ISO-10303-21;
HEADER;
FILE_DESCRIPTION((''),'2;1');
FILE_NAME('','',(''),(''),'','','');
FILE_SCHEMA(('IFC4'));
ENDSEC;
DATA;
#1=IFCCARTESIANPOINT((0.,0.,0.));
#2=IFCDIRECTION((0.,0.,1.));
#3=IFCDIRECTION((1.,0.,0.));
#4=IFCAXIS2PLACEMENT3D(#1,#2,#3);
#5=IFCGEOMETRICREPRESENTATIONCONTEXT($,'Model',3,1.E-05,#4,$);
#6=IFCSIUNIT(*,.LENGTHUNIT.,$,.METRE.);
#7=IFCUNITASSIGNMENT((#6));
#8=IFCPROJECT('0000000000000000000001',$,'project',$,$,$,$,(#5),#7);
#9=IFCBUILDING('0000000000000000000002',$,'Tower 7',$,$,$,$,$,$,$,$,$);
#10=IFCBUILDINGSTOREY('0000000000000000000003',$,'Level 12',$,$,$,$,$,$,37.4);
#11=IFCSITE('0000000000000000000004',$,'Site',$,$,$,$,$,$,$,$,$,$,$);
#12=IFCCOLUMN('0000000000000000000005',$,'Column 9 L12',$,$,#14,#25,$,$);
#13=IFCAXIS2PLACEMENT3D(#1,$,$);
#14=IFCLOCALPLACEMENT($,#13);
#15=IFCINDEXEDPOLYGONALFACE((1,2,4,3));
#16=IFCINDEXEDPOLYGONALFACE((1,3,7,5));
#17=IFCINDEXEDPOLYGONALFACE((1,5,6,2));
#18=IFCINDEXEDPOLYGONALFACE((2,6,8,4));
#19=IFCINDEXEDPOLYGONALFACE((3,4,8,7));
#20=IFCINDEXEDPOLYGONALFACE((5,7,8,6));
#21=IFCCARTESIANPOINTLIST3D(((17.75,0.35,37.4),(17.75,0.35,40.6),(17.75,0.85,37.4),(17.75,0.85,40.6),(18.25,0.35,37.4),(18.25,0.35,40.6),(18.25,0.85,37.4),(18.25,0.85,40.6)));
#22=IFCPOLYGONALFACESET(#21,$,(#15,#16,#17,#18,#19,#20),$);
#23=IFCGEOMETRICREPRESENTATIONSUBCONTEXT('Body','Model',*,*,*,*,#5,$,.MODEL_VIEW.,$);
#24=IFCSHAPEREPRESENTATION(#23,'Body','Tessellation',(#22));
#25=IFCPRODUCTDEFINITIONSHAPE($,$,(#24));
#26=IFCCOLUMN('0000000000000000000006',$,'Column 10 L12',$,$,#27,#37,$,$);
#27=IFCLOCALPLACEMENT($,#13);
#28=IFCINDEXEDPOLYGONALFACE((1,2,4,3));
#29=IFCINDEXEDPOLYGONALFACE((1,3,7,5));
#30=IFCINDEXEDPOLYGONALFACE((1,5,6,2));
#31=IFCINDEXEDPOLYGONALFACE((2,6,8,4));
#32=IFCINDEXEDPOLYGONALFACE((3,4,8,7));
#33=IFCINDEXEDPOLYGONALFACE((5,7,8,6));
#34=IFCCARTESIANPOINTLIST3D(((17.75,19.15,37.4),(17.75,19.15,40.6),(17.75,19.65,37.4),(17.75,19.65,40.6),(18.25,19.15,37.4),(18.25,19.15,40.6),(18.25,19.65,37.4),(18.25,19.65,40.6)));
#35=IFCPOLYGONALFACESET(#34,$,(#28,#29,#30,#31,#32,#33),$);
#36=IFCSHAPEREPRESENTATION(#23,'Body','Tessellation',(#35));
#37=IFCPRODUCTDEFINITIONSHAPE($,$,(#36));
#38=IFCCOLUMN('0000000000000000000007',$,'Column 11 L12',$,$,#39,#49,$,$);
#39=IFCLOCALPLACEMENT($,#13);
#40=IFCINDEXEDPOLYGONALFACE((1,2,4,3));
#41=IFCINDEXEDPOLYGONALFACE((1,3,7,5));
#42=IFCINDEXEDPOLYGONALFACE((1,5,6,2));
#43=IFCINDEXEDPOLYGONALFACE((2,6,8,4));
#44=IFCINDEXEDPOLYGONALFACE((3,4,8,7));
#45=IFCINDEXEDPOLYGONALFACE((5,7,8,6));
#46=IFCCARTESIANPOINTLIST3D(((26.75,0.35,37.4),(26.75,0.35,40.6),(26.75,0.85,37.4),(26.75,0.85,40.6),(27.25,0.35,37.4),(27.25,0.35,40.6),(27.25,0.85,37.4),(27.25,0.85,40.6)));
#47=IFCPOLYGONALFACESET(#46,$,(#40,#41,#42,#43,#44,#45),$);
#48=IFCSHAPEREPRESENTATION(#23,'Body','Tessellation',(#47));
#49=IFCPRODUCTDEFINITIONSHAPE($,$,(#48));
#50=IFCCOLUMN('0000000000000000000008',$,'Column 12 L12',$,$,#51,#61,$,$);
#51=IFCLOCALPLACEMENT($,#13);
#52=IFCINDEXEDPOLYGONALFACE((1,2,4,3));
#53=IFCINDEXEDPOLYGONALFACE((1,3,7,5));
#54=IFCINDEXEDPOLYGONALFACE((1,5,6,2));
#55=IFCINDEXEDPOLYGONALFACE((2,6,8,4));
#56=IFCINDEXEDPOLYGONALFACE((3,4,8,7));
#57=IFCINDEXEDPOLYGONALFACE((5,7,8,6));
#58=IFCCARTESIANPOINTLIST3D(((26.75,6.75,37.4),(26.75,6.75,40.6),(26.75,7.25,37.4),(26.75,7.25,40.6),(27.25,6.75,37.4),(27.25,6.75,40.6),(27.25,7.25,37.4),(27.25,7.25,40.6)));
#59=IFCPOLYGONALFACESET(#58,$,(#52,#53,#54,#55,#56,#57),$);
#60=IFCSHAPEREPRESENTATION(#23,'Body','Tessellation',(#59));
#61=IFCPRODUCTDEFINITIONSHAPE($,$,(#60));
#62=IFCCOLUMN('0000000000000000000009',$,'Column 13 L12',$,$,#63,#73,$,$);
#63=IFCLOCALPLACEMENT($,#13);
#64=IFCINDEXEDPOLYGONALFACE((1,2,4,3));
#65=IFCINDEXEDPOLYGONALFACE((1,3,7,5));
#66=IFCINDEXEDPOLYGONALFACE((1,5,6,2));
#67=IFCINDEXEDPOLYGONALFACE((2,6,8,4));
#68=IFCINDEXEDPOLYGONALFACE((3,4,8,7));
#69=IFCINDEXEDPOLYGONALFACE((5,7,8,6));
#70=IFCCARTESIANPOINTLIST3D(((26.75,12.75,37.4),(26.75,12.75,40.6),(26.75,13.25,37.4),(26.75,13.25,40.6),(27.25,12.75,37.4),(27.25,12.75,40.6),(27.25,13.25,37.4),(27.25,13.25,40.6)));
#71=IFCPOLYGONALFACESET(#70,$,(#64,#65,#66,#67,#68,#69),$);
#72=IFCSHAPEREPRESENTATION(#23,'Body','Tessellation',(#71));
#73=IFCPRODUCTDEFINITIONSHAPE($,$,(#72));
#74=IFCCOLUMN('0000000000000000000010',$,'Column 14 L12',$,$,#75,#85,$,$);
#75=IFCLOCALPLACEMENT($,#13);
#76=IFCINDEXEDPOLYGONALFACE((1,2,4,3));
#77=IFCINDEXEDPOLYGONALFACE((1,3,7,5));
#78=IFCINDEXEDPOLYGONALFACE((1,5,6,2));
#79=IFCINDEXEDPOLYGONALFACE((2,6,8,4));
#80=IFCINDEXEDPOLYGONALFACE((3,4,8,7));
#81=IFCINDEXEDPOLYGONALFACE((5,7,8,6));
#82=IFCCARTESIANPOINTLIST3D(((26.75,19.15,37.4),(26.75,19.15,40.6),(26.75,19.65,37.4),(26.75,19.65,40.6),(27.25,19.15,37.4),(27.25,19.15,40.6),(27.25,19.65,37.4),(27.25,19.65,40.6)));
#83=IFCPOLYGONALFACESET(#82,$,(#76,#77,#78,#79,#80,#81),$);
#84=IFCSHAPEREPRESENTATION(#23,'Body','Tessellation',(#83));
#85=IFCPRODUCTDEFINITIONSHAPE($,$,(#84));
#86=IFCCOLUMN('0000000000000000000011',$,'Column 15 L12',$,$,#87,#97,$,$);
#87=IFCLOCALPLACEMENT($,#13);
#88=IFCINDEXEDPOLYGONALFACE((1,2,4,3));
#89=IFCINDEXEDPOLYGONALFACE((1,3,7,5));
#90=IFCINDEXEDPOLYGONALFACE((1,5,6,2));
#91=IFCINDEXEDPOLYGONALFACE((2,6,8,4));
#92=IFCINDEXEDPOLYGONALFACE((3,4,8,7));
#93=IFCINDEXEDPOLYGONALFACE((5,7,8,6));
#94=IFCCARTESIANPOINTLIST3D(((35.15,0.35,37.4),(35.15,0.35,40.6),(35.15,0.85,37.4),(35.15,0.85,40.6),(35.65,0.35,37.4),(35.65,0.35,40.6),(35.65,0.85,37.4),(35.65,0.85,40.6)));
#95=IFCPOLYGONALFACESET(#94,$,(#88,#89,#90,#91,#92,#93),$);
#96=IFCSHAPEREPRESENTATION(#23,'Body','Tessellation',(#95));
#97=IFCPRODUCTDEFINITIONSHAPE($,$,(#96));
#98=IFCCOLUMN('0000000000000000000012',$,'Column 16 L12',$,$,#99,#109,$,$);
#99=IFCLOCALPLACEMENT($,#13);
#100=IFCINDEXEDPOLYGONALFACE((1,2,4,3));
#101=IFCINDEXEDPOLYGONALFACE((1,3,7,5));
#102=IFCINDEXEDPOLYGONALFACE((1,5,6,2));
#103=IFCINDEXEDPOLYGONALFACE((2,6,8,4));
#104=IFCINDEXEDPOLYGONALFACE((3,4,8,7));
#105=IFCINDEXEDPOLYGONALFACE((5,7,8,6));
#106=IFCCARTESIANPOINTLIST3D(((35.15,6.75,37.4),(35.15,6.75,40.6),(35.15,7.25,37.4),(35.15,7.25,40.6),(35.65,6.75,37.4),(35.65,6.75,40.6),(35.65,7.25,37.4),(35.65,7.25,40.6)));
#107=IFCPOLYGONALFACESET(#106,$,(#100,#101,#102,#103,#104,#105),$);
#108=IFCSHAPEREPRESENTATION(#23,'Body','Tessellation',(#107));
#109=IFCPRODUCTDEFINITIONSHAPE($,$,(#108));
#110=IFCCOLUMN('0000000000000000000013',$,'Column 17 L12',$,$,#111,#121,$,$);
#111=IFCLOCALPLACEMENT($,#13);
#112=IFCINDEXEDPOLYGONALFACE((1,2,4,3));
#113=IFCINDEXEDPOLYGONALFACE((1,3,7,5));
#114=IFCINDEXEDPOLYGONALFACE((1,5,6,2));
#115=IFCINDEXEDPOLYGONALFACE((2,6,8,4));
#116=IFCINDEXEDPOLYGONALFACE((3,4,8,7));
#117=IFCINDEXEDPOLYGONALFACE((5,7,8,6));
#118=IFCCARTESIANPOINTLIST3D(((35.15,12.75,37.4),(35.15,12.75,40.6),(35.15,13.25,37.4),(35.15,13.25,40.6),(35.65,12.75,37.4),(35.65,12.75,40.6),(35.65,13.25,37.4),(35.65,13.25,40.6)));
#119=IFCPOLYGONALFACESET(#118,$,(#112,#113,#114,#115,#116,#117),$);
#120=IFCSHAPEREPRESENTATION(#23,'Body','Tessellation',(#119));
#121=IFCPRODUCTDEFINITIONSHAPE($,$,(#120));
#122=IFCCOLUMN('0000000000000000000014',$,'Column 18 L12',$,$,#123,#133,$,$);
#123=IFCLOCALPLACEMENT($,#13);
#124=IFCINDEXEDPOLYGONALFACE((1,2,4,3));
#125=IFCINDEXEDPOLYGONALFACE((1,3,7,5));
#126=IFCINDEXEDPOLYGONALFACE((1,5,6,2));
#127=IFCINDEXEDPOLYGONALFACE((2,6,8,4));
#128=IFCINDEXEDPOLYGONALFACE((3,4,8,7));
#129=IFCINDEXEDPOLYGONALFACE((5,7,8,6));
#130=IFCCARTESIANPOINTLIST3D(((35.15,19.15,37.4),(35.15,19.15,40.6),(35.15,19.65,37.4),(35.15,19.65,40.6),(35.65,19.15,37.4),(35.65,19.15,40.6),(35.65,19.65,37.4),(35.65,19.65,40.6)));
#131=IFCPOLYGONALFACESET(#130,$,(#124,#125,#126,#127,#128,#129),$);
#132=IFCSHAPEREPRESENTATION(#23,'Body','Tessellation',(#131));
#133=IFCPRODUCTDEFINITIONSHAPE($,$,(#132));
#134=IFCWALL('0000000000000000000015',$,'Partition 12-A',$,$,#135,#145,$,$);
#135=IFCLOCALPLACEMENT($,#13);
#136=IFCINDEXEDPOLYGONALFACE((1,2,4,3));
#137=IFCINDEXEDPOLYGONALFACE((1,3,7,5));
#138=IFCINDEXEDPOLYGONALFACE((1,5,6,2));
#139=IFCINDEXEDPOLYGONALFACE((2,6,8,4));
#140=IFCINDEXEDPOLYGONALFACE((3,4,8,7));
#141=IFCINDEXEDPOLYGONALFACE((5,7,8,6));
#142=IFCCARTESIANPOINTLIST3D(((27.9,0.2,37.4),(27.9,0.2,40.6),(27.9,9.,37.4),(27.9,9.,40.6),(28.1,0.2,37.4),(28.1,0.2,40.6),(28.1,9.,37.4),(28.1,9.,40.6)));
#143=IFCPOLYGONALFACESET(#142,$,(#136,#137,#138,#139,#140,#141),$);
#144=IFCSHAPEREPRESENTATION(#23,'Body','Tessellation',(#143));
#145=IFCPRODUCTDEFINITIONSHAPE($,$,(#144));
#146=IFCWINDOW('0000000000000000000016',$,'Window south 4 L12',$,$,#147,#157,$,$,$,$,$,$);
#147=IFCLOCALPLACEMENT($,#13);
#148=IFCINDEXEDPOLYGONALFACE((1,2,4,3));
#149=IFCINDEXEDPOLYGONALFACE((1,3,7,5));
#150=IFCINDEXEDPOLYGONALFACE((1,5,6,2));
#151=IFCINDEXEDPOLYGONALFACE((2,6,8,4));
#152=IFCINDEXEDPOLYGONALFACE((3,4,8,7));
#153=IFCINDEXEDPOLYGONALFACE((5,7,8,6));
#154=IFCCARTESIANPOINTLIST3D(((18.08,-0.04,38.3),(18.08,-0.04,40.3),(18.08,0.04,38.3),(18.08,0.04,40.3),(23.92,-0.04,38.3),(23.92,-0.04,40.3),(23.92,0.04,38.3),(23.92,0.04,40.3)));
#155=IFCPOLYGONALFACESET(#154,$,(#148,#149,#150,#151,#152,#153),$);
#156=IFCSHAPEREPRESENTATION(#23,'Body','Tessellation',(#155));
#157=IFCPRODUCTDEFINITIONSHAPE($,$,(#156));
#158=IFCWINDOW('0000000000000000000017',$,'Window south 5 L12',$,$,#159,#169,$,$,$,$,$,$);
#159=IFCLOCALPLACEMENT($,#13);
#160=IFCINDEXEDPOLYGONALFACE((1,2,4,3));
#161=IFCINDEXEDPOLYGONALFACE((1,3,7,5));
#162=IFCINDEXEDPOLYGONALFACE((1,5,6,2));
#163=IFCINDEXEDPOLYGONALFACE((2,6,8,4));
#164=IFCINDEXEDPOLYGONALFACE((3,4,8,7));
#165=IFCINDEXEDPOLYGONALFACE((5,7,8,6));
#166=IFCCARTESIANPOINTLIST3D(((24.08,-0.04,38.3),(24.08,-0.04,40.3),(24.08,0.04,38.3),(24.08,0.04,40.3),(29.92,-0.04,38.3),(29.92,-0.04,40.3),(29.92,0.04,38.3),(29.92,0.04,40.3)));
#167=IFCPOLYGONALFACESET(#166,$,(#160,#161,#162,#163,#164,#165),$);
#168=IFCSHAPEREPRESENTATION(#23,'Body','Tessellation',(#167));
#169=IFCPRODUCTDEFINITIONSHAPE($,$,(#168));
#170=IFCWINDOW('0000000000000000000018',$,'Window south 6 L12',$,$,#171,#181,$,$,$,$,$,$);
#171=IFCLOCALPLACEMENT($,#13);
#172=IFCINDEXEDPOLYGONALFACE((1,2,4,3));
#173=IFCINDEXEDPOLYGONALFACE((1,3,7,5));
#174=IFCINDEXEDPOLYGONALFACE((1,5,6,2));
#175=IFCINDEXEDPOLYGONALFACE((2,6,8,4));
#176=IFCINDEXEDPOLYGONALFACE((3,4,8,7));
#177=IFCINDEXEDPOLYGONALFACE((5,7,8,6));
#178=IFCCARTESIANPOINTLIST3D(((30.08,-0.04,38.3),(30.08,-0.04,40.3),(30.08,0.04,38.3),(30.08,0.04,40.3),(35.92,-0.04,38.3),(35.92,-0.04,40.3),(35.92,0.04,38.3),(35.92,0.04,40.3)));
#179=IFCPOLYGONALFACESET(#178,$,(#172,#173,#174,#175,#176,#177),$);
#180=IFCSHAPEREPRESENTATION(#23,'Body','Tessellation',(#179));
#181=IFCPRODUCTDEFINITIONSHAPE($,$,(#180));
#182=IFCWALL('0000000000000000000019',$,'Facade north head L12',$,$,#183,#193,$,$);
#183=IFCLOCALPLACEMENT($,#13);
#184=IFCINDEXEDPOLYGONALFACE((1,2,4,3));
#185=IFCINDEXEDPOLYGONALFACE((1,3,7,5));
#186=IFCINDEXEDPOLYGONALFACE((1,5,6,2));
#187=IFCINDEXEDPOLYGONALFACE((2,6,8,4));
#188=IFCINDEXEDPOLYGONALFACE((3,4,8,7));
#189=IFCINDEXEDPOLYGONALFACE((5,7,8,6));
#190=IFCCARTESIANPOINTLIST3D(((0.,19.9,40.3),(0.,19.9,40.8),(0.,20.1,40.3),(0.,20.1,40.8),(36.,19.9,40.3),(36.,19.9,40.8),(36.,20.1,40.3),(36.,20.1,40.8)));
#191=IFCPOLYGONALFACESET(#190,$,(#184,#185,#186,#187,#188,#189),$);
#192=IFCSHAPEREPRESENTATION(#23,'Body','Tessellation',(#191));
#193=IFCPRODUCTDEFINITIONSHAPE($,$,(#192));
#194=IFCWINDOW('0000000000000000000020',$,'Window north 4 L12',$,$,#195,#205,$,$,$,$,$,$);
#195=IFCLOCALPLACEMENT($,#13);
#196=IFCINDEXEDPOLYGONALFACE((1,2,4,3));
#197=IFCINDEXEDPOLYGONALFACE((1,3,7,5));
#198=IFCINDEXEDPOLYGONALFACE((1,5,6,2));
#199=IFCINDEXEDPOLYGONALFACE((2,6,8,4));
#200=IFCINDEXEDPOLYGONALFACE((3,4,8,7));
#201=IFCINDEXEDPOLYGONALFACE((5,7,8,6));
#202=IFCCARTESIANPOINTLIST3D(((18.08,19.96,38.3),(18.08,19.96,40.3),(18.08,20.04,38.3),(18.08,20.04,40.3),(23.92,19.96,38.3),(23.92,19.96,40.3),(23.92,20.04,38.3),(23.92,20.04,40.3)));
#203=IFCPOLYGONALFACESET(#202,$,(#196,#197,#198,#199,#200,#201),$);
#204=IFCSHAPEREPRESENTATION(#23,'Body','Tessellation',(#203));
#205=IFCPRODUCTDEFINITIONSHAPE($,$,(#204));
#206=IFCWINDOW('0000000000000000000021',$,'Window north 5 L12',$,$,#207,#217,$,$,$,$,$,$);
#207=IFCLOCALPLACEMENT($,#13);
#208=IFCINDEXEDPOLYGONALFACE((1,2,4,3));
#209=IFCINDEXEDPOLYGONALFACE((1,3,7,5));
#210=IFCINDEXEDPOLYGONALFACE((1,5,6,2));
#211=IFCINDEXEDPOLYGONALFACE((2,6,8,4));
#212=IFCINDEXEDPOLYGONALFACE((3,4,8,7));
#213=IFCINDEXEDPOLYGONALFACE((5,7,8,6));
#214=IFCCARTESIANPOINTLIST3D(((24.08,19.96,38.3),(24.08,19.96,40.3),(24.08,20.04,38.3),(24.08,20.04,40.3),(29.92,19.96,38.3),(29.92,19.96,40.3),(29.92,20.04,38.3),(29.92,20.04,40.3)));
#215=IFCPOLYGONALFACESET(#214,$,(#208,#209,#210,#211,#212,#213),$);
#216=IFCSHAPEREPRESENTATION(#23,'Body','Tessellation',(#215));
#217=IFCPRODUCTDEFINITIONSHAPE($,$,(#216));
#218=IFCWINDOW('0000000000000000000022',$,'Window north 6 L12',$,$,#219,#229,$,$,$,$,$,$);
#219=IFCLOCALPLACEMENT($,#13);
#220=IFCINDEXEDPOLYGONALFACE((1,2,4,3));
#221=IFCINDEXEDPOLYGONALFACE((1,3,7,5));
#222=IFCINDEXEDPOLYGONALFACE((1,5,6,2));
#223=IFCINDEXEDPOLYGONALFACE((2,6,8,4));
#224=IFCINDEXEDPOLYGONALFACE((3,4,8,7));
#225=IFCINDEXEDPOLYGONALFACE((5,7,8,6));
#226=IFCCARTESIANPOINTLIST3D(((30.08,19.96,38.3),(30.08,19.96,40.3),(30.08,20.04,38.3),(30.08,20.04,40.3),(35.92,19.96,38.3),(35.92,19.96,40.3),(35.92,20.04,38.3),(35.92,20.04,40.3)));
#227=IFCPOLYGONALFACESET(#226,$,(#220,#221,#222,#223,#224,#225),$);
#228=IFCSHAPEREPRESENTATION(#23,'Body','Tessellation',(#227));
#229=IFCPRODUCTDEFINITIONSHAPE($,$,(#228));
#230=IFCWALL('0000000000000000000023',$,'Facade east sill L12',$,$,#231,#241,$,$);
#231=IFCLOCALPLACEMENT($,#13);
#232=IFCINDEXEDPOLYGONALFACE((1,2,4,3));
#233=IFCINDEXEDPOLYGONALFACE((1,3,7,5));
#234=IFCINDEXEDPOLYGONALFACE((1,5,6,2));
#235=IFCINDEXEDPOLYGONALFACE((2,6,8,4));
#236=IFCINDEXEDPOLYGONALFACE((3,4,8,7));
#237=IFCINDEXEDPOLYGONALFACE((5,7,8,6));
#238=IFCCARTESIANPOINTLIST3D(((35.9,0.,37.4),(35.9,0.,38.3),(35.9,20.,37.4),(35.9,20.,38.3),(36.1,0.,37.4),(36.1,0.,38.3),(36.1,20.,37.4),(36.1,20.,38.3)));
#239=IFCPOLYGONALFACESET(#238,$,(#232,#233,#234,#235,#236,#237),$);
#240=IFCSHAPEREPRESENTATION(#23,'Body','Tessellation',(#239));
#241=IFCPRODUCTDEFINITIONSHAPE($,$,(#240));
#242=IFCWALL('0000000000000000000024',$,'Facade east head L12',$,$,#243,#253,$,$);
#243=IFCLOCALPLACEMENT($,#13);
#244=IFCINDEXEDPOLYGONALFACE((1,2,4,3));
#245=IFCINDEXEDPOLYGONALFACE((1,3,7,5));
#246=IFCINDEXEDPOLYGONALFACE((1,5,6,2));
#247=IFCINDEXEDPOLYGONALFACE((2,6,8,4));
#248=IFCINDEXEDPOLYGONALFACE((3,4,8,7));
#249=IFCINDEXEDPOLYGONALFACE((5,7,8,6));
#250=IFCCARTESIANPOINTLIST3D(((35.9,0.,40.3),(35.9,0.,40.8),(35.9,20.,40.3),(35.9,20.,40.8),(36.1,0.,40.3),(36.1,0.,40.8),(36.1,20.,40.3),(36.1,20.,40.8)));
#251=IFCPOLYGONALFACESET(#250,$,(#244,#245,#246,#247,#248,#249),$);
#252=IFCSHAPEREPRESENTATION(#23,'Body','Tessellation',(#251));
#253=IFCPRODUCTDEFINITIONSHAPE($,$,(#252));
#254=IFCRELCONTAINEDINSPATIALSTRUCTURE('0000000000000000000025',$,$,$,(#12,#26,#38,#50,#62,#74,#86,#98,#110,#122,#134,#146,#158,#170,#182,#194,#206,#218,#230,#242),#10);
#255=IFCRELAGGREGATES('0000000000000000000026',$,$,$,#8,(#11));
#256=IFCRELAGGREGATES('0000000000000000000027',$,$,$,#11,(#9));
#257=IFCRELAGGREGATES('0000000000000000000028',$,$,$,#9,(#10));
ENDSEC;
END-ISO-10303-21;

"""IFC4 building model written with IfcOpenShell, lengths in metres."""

from ifc_helpers import new_model, si_unit, frame, origin, origin_with_axes, origin_2d, place, context, subcontext, project, spatial, rectangle, extrude, element, save


model = new_model("IFC4")

# Units and contexts
model_context = context("Model", 3, precision=1e-05, world=origin_with_axes())
body_context = subcontext(model_context, "Body", "Model", "MODEL_VIEW")
ifc_project = project(units=[si_unit("LENGTHUNIT", "METRE")], contexts=[model_context])

# Site, building, storey
site = spatial("IfcSite", under=ifc_project, Name="Site")
building = spatial("IfcBuilding", under=site, Name="Tower 7")
storey = spatial("IfcBuildingStorey", under=building, Name="Level 12", Elevation=37.4)

# Columns
for number, where, z_axis, x_axis, name in (
    (1, (18.0, 0.6, 37.4), (0.0, 0.0, 1.0), (1.0, 0.0, 0.0), "Column 9 L12"),
    (2, (18.0, 19.4, 37.4), (0.0, 0.0, 1.0), (1.0, 0.0, 0.0), "Column 10 L12"),
    (3, (27.0, 0.6, 37.4), (0.0, 0.0, 1.0), (1.0, 0.0, 0.0), "Column 11 L12"),
    (4, (27.0, 7.0, 37.4), (0.0, 0.0, 1.0), (1.0, 0.0, 0.0), "Column 12 L12"),
    (5, (27.0, 13.0, 37.4), (0.0, 0.0, 1.0), (1.0, 0.0, 0.0), "Column 13 L12"),
    (6, (27.0, 19.4, 37.4), (0.0, 0.0, 1.0), (1.0, 0.0, 0.0), "Column 14 L12"),
    (7, (35.4, 0.6, 37.4), (0.0, 0.0, 1.0), (1.0, 0.0, 0.0), "Column 15 L12"),
    (8, (35.4, 7.0, 37.4), (0.0, 0.0, 1.0), (1.0, 0.0, 0.0), "Column 16 L12"),
    (9, (35.4, 13.0, 37.4), (0.0, 0.0, 1.0), (1.0, 0.0, 0.0), "Column 17 L12"),
    (10, (35.4, 19.4, 37.4), (0.0, 0.0, 1.0), (1.0, 0.0, 0.0), "Column 18 L12"),
):
    element("IfcColumn", number, at=place(None, frame(where, z_axis=z_axis, x_axis=x_axis)), inside=storey, Name=name, context=body_context, shape_type="SweptSolid", body=[
        extrude(rectangle(XDim=0.5, YDim=0.5, at=origin_2d()), origin(), (0.0, 0.0, 1.0), 3.2),
    ])

# Wall
wall_1_placement = place(None, frame((28.0, 4.6, 37.4), z_axis=(0.0, 0.0, 1.0), x_axis=(1.0, 0.0, 0.0)))
element("IfcWall", 11, at=wall_1_placement, inside=storey, Name="Partition 12-A", context=body_context, shape_type="SweptSolid", body=[
    extrude(rectangle(XDim=0.2, YDim=8.8, at=origin_2d()), origin(), (0.0, 0.0, 1.0), 3.2),
])

# Windows
for number, where, z_axis, x_axis, name in (
    (12, (21.0, 0.0, 38.3), (0.0, 0.0, 1.0), (1.0, 0.0, 0.0), "Window south 4 L12"),
    (13, (27.0, 0.0, 38.3), (0.0, 0.0, 1.0), (1.0, 0.0, 0.0), "Window south 5 L12"),
    (14, (33.0, 0.0, 38.3), (0.0, 0.0, 1.0), (1.0, 0.0, 0.0), "Window south 6 L12"),
):
    element("IfcWindow", number, at=place(None, frame(where, z_axis=z_axis, x_axis=x_axis)), inside=storey, Name=name, context=body_context, shape_type="SweptSolid", body=[
        extrude(rectangle(XDim=5.84, YDim=0.08, at=origin_2d()), origin(), (0.0, 0.0, 1.0), 2.0),
    ])

# Wall
wall_2_placement = place(None, frame((18.0, 20.0, 40.3), z_axis=(0.0, 0.0, 1.0), x_axis=(1.0, 0.0, 0.0)))
element("IfcWall", 15, at=wall_2_placement, inside=storey, Name="Facade north head L12", context=body_context, shape_type="SweptSolid", body=[
    extrude(rectangle(XDim=36.0, YDim=0.2, at=origin_2d()), origin(), (0.0, 0.0, 1.0), 0.5),
])

# Windows
for number, where, z_axis, x_axis, name in (
    (16, (21.0, 20.0, 38.3), (0.0, 0.0, 1.0), (1.0, 0.0, 0.0), "Window north 4 L12"),
    (17, (27.0, 20.0, 38.3), (0.0, 0.0, 1.0), (1.0, 0.0, 0.0), "Window north 5 L12"),
    (18, (33.0, 20.0, 38.3), (0.0, 0.0, 1.0), (1.0, 0.0, 0.0), "Window north 6 L12"),
):
    element("IfcWindow", number, at=place(None, frame(where, z_axis=z_axis, x_axis=x_axis)), inside=storey, Name=name, context=body_context, shape_type="SweptSolid", body=[
        extrude(rectangle(XDim=5.84, YDim=0.08, at=origin_2d()), origin(), (0.0, 0.0, 1.0), 2.0),
    ])

# Walls
wall_3_placement = place(None, frame((36.0, 10.0, 37.4), z_axis=(0.0, 0.0, 1.0), x_axis=(1.0, 0.0, 0.0)))
element("IfcWall", 19, at=wall_3_placement, inside=storey, Name="Facade east sill L12", context=body_context, shape_type="SweptSolid", body=[
    extrude(rectangle(XDim=0.2, YDim=20.0, at=origin_2d()), origin(), (0.0, 0.0, 1.0), 0.9),
])
wall_4_placement = place(None, frame((36.0, 10.0, 40.3), z_axis=(0.0, 0.0, 1.0), x_axis=(1.0, 0.0, 0.0)))
element("IfcWall", 20, at=wall_4_placement, inside=storey, Name="Facade east head L12", context=body_context, shape_type="SweptSolid", body=[
    extrude(rectangle(XDim=0.2, YDim=20.0, at=origin_2d()), origin(), (0.0, 0.0, 1.0), 0.5),
])

save(model, "model.ifc")
